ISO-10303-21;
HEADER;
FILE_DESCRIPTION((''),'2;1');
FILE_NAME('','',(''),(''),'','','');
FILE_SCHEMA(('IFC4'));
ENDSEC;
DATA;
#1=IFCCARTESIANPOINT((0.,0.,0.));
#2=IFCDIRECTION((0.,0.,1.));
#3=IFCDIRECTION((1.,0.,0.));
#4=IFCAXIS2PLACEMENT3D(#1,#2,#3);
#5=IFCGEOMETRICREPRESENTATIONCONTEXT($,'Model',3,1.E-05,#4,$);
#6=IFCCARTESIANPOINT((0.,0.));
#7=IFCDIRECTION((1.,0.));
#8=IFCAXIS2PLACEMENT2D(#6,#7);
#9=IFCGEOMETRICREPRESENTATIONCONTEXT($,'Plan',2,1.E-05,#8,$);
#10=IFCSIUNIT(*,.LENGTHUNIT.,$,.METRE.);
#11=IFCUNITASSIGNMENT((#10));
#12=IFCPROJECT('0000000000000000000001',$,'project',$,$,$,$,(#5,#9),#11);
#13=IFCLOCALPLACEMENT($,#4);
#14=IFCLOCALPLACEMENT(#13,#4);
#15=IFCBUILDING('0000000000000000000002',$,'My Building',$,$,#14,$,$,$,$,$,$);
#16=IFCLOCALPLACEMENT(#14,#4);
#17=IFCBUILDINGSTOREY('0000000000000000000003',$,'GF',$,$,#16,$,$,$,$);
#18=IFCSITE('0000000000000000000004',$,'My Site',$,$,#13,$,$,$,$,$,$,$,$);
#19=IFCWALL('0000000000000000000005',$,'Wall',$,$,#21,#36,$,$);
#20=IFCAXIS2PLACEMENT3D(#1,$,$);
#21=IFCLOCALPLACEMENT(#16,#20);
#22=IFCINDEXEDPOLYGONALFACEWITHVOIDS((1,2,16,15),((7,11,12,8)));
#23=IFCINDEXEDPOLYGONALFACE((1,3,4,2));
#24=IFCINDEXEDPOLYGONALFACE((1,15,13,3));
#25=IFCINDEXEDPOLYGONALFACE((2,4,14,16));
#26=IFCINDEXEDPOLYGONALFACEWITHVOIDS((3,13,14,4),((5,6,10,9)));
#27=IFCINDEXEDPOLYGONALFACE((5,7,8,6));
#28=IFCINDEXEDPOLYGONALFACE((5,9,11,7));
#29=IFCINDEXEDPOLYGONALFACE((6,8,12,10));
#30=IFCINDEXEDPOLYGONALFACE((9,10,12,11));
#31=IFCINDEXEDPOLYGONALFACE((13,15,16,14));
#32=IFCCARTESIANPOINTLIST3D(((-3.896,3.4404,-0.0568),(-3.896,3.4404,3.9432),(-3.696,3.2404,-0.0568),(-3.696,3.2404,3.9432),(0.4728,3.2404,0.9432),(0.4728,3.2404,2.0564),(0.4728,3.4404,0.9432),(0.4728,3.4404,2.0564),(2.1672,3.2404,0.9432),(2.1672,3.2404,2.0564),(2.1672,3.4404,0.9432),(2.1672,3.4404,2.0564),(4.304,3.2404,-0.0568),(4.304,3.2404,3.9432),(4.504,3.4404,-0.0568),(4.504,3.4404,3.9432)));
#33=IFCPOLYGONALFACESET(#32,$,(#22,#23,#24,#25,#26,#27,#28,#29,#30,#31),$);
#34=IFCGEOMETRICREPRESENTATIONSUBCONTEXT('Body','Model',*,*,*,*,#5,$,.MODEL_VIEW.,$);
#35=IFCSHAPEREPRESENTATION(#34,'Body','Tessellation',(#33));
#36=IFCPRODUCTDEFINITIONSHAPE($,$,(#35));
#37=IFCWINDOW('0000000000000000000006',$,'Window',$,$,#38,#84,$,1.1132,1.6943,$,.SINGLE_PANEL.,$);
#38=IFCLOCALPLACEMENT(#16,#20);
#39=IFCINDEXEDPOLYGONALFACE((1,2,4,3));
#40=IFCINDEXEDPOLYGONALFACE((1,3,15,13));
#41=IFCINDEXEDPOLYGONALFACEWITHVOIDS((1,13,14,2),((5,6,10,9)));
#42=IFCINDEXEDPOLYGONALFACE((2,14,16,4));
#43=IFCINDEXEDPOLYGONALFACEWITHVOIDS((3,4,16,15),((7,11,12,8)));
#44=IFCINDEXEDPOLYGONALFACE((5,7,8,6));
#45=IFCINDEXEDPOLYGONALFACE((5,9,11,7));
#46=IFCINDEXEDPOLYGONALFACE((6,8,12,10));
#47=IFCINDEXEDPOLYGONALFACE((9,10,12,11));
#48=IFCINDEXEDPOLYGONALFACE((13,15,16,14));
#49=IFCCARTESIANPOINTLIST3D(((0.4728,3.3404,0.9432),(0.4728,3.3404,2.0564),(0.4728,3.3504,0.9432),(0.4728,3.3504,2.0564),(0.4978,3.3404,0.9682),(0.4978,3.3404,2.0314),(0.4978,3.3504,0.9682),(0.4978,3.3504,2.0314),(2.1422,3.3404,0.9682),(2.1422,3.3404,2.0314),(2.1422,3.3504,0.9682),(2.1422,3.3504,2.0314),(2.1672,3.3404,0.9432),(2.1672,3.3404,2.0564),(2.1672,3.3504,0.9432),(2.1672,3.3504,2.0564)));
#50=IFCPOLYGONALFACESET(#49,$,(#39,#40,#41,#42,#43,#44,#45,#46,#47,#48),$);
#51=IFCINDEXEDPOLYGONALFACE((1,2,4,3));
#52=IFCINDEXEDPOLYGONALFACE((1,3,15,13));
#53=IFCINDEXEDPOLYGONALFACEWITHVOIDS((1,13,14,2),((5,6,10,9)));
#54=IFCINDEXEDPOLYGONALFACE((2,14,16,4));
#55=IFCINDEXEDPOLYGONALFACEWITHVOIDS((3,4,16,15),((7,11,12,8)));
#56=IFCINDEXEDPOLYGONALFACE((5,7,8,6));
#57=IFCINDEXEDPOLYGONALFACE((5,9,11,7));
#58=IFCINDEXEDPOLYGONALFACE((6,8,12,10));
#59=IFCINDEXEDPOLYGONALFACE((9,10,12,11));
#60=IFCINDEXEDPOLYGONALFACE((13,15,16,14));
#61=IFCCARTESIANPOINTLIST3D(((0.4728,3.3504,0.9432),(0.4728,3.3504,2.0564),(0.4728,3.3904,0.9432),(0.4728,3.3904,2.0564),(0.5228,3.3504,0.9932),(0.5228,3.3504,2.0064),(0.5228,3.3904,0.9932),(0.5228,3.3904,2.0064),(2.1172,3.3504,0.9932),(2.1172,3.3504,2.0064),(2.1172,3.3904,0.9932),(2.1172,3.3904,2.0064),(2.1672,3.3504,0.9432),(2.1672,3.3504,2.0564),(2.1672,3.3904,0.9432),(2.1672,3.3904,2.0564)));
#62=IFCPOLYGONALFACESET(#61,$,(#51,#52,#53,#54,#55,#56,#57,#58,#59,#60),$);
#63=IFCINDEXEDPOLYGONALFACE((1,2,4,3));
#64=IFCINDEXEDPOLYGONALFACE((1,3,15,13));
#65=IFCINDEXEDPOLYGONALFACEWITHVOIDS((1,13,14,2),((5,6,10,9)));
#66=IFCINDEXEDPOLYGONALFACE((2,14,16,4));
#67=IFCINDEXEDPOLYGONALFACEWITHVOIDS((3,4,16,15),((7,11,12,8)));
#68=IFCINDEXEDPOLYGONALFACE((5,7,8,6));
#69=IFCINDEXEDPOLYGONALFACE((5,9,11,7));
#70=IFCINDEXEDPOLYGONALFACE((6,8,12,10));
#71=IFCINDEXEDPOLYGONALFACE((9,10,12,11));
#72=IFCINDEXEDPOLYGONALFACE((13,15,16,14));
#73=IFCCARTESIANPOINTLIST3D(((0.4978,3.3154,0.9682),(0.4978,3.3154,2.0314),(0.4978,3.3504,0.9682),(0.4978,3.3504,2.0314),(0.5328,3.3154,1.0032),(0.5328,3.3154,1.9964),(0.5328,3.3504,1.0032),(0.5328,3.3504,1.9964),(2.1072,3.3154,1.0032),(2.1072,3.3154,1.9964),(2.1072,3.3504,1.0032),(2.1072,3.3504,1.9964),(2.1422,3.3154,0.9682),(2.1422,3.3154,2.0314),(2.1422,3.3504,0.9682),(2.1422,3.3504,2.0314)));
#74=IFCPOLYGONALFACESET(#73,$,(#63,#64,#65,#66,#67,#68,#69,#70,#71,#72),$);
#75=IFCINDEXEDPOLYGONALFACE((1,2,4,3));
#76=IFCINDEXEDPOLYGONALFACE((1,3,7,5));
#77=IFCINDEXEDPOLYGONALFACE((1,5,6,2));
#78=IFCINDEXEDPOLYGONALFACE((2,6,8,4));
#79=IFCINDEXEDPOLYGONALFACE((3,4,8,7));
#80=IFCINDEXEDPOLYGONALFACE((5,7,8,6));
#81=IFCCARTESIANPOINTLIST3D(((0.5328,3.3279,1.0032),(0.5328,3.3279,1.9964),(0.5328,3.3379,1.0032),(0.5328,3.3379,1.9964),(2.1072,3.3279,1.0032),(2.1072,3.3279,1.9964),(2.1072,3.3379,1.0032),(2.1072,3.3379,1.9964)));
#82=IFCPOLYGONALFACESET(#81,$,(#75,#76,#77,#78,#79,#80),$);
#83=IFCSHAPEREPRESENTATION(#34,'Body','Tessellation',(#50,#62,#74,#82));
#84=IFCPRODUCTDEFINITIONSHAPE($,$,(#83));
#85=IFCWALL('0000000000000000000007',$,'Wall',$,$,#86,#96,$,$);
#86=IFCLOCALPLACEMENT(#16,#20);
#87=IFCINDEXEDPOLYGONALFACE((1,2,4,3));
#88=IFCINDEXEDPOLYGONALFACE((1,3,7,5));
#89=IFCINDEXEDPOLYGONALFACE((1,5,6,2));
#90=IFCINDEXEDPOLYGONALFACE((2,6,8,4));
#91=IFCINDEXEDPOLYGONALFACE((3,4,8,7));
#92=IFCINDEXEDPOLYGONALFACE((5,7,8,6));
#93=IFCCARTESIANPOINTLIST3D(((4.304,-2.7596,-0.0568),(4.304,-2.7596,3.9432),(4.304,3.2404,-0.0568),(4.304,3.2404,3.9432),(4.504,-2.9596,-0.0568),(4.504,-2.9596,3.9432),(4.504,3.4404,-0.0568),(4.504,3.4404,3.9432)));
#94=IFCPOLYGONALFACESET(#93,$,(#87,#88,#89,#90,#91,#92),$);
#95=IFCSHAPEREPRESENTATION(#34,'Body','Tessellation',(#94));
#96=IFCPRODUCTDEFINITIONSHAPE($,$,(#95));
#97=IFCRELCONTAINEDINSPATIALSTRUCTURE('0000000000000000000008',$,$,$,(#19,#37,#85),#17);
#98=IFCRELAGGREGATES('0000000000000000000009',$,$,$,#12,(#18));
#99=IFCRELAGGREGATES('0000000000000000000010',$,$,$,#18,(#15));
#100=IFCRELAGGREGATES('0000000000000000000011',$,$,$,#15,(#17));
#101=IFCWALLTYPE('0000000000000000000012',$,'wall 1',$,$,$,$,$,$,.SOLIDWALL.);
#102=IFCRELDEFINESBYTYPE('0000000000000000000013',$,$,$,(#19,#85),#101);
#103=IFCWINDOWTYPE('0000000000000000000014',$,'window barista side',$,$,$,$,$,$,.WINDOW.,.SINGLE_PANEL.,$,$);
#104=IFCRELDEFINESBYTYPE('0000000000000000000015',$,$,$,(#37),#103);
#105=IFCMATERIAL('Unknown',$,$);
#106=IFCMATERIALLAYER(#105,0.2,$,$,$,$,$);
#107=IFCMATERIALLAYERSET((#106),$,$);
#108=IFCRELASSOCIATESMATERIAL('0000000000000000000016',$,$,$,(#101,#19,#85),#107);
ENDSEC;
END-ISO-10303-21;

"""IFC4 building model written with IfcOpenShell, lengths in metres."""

from ifc_helpers import new_model, entity, si_unit, frame, origin_with_axes, origin_2d_with_axis, place, context, subcontext, project, spatial, line, indexed_curve, outline, extrude, shape, source, transform, mapped, material, layer, layer_set, layer_usage, type_object, type_shapes, element, fill, save


model = new_model("IFC4")

# Units and contexts
model_context = context("Model", 3, precision=1e-05, world=origin_with_axes())
plan_context = context("Plan", 2, precision=1e-05, world=origin_2d_with_axis())
body_context_1 = subcontext(model_context, "Body", "Model", "MODEL_VIEW")
body_context_2 = subcontext(plan_context, "Body", "Plan", "PLAN_VIEW")
ifc_project = project(units=[si_unit("LENGTHUNIT", "METRE")], contexts=[model_context, plan_context])

# Site, building, storey
site_placement = place(None, origin_with_axes())
site = spatial("IfcSite", under=ifc_project, at=site_placement, Name="My Site")
building_placement = place(site_placement, origin_with_axes())
building = spatial("IfcBuilding", under=site, at=building_placement, Name="My Building")
storey_placement = place(building_placement, origin_with_axes())
storey = spatial("IfcBuildingStorey", under=building, at=storey_placement, Name="GF")

# Shared definitions
ifc_material = material(Name="Unknown")

# Wall, opening, window
ifc_layer_1 = layer(ifc_material, 0.2)
ifc_layer_set_1 = layer_set([ifc_layer_1])
ifc_layer_usage_1 = layer_usage(ifc_layer_set_1, "AXIS2", "POSITIVE", 0.0)
wall_type_1 = type_object("IfcWallType", Name="wall 1", PredefinedType="SOLIDWALL", material=ifc_layer_set_1)
wall_1_placement = place(storey_placement, frame((-3.696, 3.2404, -0.0568), z_axis=(0.0, 0.0, 1.0), x_axis=(1.0, 0.0, 0.0)))
wall_1 = element("IfcWall", 1, at=wall_1_placement, inside=storey, type_object=wall_type_1, material=ifc_layer_usage_1, Name="Wall", context=body_context_1, shape_type="SweptSolid", body=[
    extrude(outline(indexed_curve([(0.0, 0.0), (-0.2, 0.2), (8.2, 0.2), (8.0, 0.0)], segments=[line(1, 2, 3, 4, 1)])), origin_with_axes(), (0.0, 0.0, 1.0), 4.0),
])
shared_shape_1 = source(origin_with_axes(), body_context_1, "Body", "SweptSolid", [
    extrude(outline(indexed_curve([(0.0, 0.0), (1.6943, 0.0), (1.6943, 1.1132), (0.0, 1.1132)], segments=[line(1, 2, 3, 4, 1)])), frame((0.0, -0.6, 0.0), z_axis=(0.0, -1.0, 0.0), x_axis=(1.0, 0.0, 0.0)), (0.0, 0.0, -1.0), 1.2),
])
opening_1_placement = place(wall_1_placement, frame((5.8632, 0.2, 1.0), z_axis=(0.0, 0.0, 1.0), x_axis=(-1.0, 0.0, 0.0)))
opening_1 = element("IfcOpeningElement", 2, at=opening_1_placement, cuts=wall_1, PredefinedType="OPENING", context=body_context_1, shape_type="MappedRepresentation", body=[
    mapped(shared_shape_1, transform((0.0, 0.0, 0.0), x_axis=(1.0, 0.0, 0.0), y_axis=(0.0, 1.0, 0.0), z_axis=(0.0, 0.0, 1.0), scale=1.0)),
])
window_type_1 = type_object("IfcWindowType", Name="window barista side", PartitioningType="SINGLE_PANEL", PredefinedType="WINDOW")
shared_shape_2 = source(origin_with_axes(), body_context_1, "Body", "SweptSolid", [
    extrude(outline(indexed_curve([(0.0, 0.0), (1.6943, 0.0), (1.6943, 1.1132), (0.0, 1.1132)], segments=[line(1, 2, 3, 4, 1)]), holes=[indexed_curve([(0.025, 0.025), (1.6693, 0.025), (1.6693, 1.0882), (0.025, 1.0882)], segments=[line(1, 2, 3, 4, 1)])]), frame((0.0, 0.09, 0.0), z_axis=(0.0, -1.0, 0.0), x_axis=(1.0, 0.0, 0.0)), (0.0, 0.0, -1.0), 0.01),
    extrude(outline(indexed_curve([(0.0, 0.0), (1.6943, 0.0), (1.6943, 1.1132), (0.0, 1.1132)], segments=[line(1, 2, 3, 4, 1)]), holes=[indexed_curve([(0.05, 0.05), (1.6443, 0.05), (1.6443, 1.0632), (0.05, 1.0632)], segments=[line(1, 2, 3, 4, 1)])]), frame((0.0, 0.05, 0.0), z_axis=(0.0, -1.0, 0.0), x_axis=(1.0, 0.0, 0.0)), (0.0, 0.0, -1.0), 0.04),
    extrude(outline(indexed_curve([(0.0, 0.0), (1.6443, 0.0), (1.6443, 1.0632), (0.0, 1.0632)], segments=[line(1, 2, 3, 4, 1)]), holes=[indexed_curve([(0.035, 0.035), (1.6093, 0.035), (1.6093, 1.0282), (0.035, 1.0282)], segments=[line(1, 2, 3, 4, 1)])]), frame((0.025, 0.09, 0.025), z_axis=(0.0, -1.0, 0.0), x_axis=(1.0, 0.0, 0.0)), (0.0, 0.0, -1.0), 0.035),
    extrude(outline(indexed_curve([(0.035, 0.035), (1.6093, 0.035), (1.6093, 1.0282), (0.035, 1.0282)], segments=[line(1, 2, 3, 4, 1)])), frame((0.025, 0.1025, 0.025), z_axis=(0.0, -1.0, 0.0), x_axis=(1.0, 0.0, 0.0)), (0.0, 0.0, -1.0), 0.01),
])
shared_shape_3 = source(origin_with_axes(), body_context_2, "Body", "Curve2D", [
    entity("IfcIndexedPolyCurve", entity("IfcCartesianPointList2D", [[0.05, 0.05], [1.6443, 0.05]])),
    entity("IfcIndexedPolyCurve", entity("IfcCartesianPointList2D", [[0.0, 0.1], [0.025, 0.1], [0.025, 0.09], [0.05, 0.09], [0.05, 0.05], [0.0, 0.05]]), [entity("IfcLineIndex", [1, 2, 3, 4, 5, 6, 1])]),
    entity("IfcIndexedPolyCurve", entity("IfcCartesianPointList2D", [[1.6943, 0.1], [1.6693, 0.1], [1.6693, 0.09], [1.6443, 0.09], [1.6443, 0.05], [1.6943, 0.05]]), [entity("IfcLineIndex", [1, 2, 3, 4, 5, 6, 1])]),
    entity("IfcIndexedPolyCurve", entity("IfcCartesianPointList2D", [[0.025, 0.09], [0.06, 0.09], [0.06, 0.125], [0.025, 0.125]]), [entity("IfcLineIndex", [1, 2, 3, 4, 1])]),
    entity("IfcIndexedPolyCurve", entity("IfcCartesianPointList2D", [[1.6693, 0.09], [1.6343, 0.09], [1.6343, 0.125], [1.6693, 0.125]]), [entity("IfcLineIndex", [1, 2, 3, 4, 1])]),
    entity("IfcIndexedPolyCurve", entity("IfcCartesianPointList2D", [[0.06, 0.09], [1.6343, 0.09]])),
    entity("IfcIndexedPolyCurve", entity("IfcCartesianPointList2D", [[0.06, 0.125], [1.6343, 0.125]])),
    entity("IfcIndexedPolyCurve", entity("IfcCartesianPointList2D", [[0.06, 0.1075], [1.6343, 0.1075]])),
])
type_shapes(window_type_1, [shared_shape_2, shared_shape_3])
window_1_placement = place(opening_1_placement, frame((0.0, 0.0, 0.0), z_axis=(0.0, 0.0, 1.0), x_axis=(1.0, 0.0, 0.0)))
window_1 = element("IfcWindow", 3, at=window_1_placement, inside=storey, type_object=window_type_1, Name="Window", OverallHeight=1.1132, OverallWidth=1.6943, PartitioningType="SINGLE_PANEL", shapes=[
    shape(body_context_1, "Body", "MappedRepresentation", [mapped(shared_shape_2, transform((0.0, 0.0, 0.0), x_axis=(1.0, 0.0, 0.0), y_axis=(0.0, 1.0, 0.0), z_axis=(0.0, 0.0, 1.0), scale=1.0))]),
    shape(body_context_2, "Body", "MappedRepresentation", [mapped(shared_shape_3, transform((0.0, 0.0, 0.0), x_axis=(1.0, 0.0, 0.0), y_axis=(0.0, 1.0, 0.0), z_axis=(0.0, 0.0, 1.0), scale=1.0))]),
])
fill(opening_1, window_1)

# Wall
ifc_layer_usage_2 = layer_usage(ifc_layer_set_1, "AXIS2", "POSITIVE", 0.0)
wall_2_placement = place(storey_placement, frame((4.304, 3.2404, -0.0568), z_axis=(0.0, 0.0, 1.0), x_axis=(0.0, -1.0, 0.0)))
element("IfcWall", 4, at=wall_2_placement, inside=storey, type_object=wall_type_1, material=ifc_layer_usage_2, Name="Wall", context=body_context_1, shape_type="SweptSolid", body=[
    extrude(outline(indexed_curve([(0.0, 0.0), (-0.2, 0.2), (6.2, 0.2), (6.0, 0.0)], segments=[line(1, 2, 3, 4, 1)])), origin_with_axes(), (0.0, 0.0, 1.0), 4.0),
])

save(model, "model.ifc")
